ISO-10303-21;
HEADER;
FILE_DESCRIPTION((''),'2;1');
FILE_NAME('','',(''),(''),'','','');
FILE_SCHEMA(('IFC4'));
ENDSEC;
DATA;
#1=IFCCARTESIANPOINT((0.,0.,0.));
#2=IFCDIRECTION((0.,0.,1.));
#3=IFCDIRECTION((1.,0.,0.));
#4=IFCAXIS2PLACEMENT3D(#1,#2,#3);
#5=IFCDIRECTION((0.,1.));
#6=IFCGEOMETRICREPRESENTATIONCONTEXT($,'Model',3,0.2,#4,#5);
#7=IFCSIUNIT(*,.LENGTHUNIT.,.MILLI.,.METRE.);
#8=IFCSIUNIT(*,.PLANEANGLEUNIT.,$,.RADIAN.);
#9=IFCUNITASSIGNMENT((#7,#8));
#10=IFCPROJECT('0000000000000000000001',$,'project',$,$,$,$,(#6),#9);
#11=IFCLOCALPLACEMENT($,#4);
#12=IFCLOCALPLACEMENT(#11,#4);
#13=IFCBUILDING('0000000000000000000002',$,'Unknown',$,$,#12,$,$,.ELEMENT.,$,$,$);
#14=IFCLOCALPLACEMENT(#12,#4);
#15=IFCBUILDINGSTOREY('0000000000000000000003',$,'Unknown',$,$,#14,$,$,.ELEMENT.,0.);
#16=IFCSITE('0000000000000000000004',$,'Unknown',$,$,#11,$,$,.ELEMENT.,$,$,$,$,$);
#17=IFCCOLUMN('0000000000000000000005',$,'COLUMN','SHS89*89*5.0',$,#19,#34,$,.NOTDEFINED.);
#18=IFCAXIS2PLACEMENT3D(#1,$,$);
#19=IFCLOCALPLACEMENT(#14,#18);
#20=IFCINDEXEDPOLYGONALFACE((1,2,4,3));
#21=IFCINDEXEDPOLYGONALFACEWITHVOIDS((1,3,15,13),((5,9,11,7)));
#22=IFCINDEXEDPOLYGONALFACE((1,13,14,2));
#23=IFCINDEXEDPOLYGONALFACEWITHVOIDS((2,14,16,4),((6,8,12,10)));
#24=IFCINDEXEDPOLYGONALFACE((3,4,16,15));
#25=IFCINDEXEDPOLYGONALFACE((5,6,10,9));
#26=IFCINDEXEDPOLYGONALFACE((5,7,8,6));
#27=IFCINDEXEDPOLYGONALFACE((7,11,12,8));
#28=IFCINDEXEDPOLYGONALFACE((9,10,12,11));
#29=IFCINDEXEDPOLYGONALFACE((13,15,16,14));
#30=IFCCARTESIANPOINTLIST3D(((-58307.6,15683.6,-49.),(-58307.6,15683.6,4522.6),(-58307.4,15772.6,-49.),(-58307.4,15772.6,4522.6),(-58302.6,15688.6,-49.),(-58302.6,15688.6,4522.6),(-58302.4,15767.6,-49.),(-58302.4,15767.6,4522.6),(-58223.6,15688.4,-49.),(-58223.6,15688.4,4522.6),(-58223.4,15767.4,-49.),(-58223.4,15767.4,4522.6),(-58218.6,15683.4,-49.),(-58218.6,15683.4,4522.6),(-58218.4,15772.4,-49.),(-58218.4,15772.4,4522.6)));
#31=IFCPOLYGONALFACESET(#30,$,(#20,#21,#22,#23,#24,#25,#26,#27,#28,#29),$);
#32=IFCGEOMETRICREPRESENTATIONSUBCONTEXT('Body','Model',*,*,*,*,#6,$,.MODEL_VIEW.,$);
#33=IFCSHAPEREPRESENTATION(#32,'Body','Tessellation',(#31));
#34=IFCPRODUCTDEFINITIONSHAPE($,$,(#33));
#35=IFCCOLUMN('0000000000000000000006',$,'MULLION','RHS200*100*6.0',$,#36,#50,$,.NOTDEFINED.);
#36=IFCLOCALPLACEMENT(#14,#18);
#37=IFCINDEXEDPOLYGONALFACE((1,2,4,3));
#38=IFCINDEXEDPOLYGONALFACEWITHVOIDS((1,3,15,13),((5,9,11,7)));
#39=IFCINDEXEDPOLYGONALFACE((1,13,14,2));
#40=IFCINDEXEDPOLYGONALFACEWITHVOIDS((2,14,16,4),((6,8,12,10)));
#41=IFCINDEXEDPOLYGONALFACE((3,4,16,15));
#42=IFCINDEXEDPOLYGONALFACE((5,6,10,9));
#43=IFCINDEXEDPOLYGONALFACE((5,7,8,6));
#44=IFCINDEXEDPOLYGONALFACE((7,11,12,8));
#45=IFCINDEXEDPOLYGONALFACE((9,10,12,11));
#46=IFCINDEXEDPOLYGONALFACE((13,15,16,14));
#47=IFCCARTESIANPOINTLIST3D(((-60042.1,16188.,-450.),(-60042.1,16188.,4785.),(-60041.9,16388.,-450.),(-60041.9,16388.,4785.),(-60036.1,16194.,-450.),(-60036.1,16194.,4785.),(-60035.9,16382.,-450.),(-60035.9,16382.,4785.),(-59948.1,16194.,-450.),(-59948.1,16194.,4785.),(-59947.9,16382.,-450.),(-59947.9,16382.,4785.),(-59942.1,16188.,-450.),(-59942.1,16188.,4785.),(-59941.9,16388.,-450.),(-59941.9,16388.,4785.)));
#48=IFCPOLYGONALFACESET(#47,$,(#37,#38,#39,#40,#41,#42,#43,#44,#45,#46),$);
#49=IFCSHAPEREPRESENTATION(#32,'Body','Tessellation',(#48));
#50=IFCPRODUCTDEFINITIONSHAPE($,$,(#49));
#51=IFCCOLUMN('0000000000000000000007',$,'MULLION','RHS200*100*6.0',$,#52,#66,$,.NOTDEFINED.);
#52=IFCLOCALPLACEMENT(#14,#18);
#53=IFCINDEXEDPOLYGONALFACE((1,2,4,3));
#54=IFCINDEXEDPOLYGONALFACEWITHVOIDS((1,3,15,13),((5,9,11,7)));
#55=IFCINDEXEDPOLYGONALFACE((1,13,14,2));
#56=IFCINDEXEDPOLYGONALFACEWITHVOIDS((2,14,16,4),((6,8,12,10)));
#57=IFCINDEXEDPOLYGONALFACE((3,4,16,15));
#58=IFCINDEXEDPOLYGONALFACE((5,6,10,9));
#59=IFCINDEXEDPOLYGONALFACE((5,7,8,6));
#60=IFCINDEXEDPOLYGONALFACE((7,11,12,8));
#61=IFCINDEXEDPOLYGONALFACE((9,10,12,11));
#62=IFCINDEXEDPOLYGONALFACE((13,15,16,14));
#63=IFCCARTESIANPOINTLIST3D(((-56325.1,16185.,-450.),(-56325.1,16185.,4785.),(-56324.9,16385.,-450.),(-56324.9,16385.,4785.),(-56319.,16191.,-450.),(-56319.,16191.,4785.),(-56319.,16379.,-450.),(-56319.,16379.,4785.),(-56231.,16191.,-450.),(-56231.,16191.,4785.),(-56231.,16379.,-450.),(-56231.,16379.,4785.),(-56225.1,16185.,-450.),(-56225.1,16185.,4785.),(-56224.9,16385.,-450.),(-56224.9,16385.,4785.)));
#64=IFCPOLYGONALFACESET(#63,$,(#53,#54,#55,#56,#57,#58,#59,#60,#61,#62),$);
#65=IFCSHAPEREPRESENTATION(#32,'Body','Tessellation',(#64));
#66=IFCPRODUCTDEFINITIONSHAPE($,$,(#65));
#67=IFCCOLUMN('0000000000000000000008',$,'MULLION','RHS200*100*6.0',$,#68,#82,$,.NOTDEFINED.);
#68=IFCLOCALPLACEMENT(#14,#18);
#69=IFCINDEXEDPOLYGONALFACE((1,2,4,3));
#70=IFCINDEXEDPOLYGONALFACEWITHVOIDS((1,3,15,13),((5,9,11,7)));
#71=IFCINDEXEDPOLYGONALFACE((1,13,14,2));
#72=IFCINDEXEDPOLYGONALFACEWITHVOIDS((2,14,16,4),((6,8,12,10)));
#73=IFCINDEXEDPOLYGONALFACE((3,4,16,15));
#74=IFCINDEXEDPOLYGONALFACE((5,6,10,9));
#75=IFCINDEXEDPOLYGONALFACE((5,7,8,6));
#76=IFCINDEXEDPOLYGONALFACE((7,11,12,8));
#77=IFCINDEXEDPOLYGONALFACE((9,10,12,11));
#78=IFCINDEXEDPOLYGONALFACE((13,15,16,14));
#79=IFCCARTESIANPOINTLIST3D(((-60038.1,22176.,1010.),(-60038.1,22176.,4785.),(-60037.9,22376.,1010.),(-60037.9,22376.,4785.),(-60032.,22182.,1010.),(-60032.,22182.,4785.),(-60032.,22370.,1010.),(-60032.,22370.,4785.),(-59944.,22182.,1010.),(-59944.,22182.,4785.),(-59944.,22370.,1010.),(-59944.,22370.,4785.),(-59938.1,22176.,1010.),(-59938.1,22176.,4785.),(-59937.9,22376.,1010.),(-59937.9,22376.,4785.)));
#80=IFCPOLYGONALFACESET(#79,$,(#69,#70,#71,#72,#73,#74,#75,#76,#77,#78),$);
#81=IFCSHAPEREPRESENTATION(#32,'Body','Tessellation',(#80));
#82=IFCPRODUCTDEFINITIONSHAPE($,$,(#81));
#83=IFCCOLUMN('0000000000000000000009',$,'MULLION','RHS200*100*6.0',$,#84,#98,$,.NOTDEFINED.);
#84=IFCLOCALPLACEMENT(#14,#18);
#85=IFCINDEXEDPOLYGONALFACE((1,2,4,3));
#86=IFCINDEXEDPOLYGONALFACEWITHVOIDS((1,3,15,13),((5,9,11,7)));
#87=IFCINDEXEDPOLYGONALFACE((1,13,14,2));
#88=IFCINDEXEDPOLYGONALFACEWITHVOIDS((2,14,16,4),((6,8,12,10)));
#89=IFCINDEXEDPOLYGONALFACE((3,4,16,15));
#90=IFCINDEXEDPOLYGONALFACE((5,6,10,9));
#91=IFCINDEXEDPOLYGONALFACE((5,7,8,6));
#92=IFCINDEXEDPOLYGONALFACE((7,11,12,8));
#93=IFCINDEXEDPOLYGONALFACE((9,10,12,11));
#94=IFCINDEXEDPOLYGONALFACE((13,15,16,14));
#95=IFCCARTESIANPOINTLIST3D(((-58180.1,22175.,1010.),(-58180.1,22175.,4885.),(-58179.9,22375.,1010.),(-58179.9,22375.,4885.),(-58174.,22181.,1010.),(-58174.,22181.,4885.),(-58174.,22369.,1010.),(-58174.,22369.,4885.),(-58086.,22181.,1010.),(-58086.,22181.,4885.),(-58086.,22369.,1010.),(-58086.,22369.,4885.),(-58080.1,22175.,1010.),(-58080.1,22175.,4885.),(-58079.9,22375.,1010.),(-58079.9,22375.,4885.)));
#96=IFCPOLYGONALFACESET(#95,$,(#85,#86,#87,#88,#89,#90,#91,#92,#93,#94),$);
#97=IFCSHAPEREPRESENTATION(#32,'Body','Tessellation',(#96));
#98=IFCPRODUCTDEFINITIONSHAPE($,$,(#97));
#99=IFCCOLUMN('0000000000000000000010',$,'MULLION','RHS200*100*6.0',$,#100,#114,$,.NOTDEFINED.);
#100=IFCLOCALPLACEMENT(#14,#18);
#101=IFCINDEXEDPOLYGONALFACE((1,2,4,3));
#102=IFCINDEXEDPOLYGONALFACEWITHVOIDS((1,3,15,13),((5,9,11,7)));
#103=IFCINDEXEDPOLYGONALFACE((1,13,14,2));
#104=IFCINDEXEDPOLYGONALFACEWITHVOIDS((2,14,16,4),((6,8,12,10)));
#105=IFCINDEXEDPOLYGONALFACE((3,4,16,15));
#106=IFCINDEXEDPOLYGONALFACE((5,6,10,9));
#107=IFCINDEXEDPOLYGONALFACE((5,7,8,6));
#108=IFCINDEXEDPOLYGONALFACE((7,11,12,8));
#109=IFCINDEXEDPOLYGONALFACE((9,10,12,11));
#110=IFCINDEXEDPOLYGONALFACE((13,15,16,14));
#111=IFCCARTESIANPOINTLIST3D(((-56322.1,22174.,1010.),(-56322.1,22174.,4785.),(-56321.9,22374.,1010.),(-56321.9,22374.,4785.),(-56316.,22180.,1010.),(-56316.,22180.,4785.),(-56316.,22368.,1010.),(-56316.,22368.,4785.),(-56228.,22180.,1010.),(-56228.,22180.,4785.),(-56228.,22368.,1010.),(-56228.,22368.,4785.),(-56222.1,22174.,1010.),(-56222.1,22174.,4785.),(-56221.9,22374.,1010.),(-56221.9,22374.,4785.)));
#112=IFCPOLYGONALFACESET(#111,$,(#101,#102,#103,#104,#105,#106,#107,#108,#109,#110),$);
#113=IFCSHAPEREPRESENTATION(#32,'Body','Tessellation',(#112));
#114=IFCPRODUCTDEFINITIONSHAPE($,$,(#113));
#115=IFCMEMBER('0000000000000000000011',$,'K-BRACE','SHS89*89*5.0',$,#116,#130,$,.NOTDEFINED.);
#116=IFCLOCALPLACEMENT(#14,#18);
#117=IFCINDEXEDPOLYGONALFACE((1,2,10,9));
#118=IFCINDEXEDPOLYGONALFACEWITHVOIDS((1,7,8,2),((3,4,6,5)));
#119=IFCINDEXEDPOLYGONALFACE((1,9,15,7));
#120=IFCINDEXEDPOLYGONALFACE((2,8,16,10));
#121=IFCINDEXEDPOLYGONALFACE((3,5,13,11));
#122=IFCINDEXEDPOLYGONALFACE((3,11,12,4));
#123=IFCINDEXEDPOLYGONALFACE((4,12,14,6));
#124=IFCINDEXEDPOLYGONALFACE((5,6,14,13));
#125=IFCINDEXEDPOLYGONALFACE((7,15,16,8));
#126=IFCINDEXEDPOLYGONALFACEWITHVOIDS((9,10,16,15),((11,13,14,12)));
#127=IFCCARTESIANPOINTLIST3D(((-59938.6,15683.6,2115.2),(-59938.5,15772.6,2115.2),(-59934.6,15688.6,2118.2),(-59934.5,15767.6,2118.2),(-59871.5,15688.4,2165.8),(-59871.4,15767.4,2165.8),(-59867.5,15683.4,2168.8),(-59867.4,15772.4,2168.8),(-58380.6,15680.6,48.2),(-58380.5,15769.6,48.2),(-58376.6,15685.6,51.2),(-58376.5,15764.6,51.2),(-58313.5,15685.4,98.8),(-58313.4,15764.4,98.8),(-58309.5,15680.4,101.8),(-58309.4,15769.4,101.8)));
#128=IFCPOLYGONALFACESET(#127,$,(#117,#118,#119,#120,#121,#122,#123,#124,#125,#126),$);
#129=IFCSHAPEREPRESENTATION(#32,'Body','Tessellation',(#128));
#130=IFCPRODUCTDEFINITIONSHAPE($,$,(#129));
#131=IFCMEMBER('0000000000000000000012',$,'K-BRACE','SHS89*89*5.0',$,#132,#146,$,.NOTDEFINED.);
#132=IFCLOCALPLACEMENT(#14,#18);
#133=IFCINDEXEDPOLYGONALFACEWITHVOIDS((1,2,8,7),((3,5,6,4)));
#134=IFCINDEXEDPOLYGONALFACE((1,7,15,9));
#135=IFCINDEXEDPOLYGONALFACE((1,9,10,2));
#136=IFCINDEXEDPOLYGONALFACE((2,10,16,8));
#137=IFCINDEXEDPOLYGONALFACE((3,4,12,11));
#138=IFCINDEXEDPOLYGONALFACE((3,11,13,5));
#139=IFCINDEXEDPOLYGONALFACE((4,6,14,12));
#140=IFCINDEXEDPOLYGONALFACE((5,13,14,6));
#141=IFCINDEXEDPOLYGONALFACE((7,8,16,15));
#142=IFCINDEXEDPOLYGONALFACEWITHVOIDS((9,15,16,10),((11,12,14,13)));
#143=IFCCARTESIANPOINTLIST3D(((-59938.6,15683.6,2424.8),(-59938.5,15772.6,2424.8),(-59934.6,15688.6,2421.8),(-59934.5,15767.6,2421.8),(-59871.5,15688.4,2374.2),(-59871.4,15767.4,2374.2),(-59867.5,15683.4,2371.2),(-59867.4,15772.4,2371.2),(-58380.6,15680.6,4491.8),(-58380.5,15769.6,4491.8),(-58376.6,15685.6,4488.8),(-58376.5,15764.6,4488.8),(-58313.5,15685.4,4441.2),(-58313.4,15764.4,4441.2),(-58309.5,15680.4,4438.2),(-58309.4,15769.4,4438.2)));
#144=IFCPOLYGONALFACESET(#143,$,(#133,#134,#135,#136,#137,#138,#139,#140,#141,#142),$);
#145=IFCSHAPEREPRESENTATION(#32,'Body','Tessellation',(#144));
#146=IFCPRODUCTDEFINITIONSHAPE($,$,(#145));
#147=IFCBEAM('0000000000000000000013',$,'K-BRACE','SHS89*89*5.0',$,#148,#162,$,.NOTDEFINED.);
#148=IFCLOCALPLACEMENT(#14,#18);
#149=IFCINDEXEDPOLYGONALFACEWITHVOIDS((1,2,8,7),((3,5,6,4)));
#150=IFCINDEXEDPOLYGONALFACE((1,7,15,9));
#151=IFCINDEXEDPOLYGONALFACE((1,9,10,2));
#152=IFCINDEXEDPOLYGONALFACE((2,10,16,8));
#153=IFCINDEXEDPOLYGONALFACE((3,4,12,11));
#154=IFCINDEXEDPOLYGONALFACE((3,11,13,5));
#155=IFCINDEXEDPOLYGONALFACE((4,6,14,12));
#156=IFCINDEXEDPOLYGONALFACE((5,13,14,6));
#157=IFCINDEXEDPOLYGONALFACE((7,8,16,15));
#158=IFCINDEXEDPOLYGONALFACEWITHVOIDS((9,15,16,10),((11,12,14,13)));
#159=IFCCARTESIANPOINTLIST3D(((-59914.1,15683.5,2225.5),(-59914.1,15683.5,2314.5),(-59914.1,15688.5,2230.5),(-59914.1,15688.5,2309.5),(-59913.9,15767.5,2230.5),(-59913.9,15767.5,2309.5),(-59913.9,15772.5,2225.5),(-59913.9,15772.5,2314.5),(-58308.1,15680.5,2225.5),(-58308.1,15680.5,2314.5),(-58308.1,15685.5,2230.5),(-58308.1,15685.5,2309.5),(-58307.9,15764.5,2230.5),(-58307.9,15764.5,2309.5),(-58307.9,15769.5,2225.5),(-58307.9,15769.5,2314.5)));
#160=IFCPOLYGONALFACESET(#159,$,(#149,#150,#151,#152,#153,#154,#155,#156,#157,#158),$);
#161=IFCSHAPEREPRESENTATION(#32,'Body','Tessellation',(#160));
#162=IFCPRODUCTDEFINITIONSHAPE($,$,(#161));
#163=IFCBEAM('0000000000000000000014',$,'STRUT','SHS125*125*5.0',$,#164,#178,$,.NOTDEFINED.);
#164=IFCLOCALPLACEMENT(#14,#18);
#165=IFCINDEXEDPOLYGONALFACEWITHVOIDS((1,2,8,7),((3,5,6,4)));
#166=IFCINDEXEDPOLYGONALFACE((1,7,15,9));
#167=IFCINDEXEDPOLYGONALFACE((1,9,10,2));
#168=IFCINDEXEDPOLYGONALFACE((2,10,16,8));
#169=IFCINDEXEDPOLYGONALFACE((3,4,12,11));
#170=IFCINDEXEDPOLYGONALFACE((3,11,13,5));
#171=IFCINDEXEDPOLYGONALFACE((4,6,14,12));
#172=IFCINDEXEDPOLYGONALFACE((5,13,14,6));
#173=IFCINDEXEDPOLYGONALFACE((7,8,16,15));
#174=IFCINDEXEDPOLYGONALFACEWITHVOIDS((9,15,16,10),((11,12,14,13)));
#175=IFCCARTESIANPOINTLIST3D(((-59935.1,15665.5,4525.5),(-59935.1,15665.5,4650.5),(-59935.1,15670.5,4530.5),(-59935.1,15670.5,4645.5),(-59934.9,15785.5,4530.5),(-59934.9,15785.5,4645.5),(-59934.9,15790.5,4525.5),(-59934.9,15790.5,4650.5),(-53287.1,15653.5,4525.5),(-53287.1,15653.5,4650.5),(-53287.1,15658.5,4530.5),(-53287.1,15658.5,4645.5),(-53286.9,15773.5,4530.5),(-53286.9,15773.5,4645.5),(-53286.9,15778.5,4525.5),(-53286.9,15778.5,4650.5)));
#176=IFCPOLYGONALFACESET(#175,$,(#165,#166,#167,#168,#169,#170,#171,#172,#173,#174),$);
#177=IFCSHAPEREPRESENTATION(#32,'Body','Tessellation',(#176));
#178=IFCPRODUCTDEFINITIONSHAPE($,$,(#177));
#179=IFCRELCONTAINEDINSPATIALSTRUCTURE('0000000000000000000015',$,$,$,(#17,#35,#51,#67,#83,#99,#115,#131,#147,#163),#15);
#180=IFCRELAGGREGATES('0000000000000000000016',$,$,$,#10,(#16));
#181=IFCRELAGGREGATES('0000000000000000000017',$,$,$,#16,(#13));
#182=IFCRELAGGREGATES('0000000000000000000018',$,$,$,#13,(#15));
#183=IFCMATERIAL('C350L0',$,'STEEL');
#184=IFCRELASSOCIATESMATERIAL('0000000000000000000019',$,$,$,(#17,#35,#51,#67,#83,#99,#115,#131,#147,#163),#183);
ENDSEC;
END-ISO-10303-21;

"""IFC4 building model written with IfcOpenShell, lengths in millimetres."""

from ifc_helpers import new_model, si_unit, direction, frame, origin_with_axes, place, context, subcontext, project, spatial, line, indexed_curve, outline, extrude, material, element, save


model = new_model("IFC4")

# Units and contexts
model_context = context("Model", 3, precision=0.2, world=origin_with_axes(), true_north=direction((0.0, 1.0)))
body_context = subcontext(model_context, "Body", "Model", "MODEL_VIEW")
ifc_project = project(units=[si_unit("LENGTHUNIT", "METRE", prefix="MILLI"), si_unit("PLANEANGLEUNIT", "RADIAN")], contexts=[model_context])

# Site, building, storey
site_placement = place(None, origin_with_axes())
site = spatial("IfcSite", under=ifc_project, at=site_placement, Name="Unknown", CompositionType="ELEMENT")
building_placement = place(site_placement, origin_with_axes())
building = spatial("IfcBuilding", under=site, at=building_placement, Name="Unknown", CompositionType="ELEMENT")
storey_placement = place(building_placement, origin_with_axes())
storey = spatial("IfcBuildingStorey", under=building, at=storey_placement, Name="Unknown", CompositionType="ELEMENT", Elevation=0.0)

# Columns
ifc_material_1 = material(Name="C350L0", Category="STEEL")
column_1_placement = place(storey_placement, frame((-58263.0, 15728.0, -49.0), z_axis=(0.001745, 0.999998, 0.0), x_axis=(0.0, 0.0, 1.0)))
element("IfcColumn", 1, at=column_1_placement, inside=storey, material=ifc_material_1, Name="COLUMN", Description="SHS89*89*5.0", PredefinedType="NOTDEFINED", context=body_context, shape_type="SolidModel", body=[
    extrude(outline(indexed_curve([(-44.5, -44.5), (44.5, -44.5), (44.5, 44.5), (-44.5, 44.5)], segments=[line(1, 2, 3, 4, 1)]), holes=[indexed_curve([(-39.5, -39.5), (-39.5, 39.5), (39.5, 39.5), (39.5, -39.5)], segments=[line(1, 2, 3, 4, 1)])]), frame((0.0, 0.0, 0.0), z_axis=(-1.0, 0.0, 0.0), x_axis=(0.0, 0.0, 1.0)), (0.0, 0.0, -1.0), 4571.6),
])
for number, where, z_axis, x_axis, name in (
    (2, (-59992.0, 16288.0, -450.0), (1.0, -0.000873, 0.0), (0.0, 0.0, 1.0), "MULLION"),
    (3, (-56275.0, 16285.0, -450.0), (1.0, -0.000524, 0.0), (0.0, 0.0, 1.0), "MULLION"),
):
    element("IfcColumn", number, at=place(storey_placement, frame(where, z_axis=z_axis, x_axis=x_axis)), inside=storey, material=ifc_material_1, Name=name, Description="RHS200*100*6.0", PredefinedType="NOTDEFINED", context=body_context, shape_type="SolidModel", body=[
        extrude(outline(indexed_curve([(-50.0, -100.0), (50.0, -100.0), (50.0, 100.0), (-50.0, 100.0)], segments=[line(1, 2, 3, 4, 1)]), holes=[indexed_curve([(-44.0, -94.0), (-44.0, 94.0), (44.0, 94.0), (44.0, -94.0)], segments=[line(1, 2, 3, 4, 1)])]), frame((0.0, 0.0, 0.0), z_axis=(-1.0, 0.0, 0.0), x_axis=(0.0, 0.0, 1.0)), (0.0, 0.0, -1.0), 5235.0),
    ])
column_2_placement = place(storey_placement, frame((-59988.0, 22276.0, 1010.0), z_axis=(1.0, -0.000524, 0.0), x_axis=(0.0, 0.0, 1.0)))
element("IfcColumn", 4, at=column_2_placement, inside=storey, material=ifc_material_1, Name="MULLION", Description="RHS200*100*6.0", PredefinedType="NOTDEFINED", context=body_context, shape_type="SolidModel", body=[
    extrude(outline(indexed_curve([(-50.0, -100.0), (50.0, -100.0), (50.0, 100.0), (-50.0, 100.0)], segments=[line(1, 2, 3, 4, 1)]), holes=[indexed_curve([(-44.0, -94.0), (-44.0, 94.0), (44.0, 94.0), (44.0, -94.0)], segments=[line(1, 2, 3, 4, 1)])]), frame((0.0, 0.0, 0.0), z_axis=(-1.0, 0.0, 0.0), x_axis=(0.0, 0.0, 1.0)), (0.0, 0.0, -1.0), 3775.0),
])
column_3_placement = place(storey_placement, frame((-58130.0, 22275.0, 1010.0), z_axis=(1.0, -0.000524, 0.0), x_axis=(0.0, 0.0, 1.0)))
element("IfcColumn", 5, at=column_3_placement, inside=storey, material=ifc_material_1, Name="MULLION", Description="RHS200*100*6.0", PredefinedType="NOTDEFINED", context=body_context, shape_type="SolidModel", body=[
    extrude(outline(indexed_curve([(-50.0, -100.0), (50.0, -100.0), (50.0, 100.0), (-50.0, 100.0)], segments=[line(1, 2, 3, 4, 1)]), holes=[indexed_curve([(-44.0, -94.0), (-44.0, 94.0), (44.0, 94.0), (44.0, -94.0)], segments=[line(1, 2, 3, 4, 1)])]), frame((0.0, 0.0, 0.0), z_axis=(-1.0, 0.0, 0.0), x_axis=(0.0, 0.0, 1.0)), (0.0, 0.0, -1.0), 3875.0),
])
column_4_placement = place(storey_placement, frame((-56272.0, 22274.0, 1010.0), z_axis=(1.0, -0.000524, 0.0), x_axis=(0.0, 0.0, 1.0)))
element("IfcColumn", 6, at=column_4_placement, inside=storey, material=ifc_material_1, Name="MULLION", Description="RHS200*100*6.0", PredefinedType="NOTDEFINED", context=body_context, shape_type="SolidModel", body=[
    extrude(outline(indexed_curve([(-50.0, -100.0), (50.0, -100.0), (50.0, 100.0), (-50.0, 100.0)], segments=[line(1, 2, 3, 4, 1)]), holes=[indexed_curve([(-44.0, -94.0), (-44.0, 94.0), (44.0, 94.0), (44.0, -94.0)], segments=[line(1, 2, 3, 4, 1)])]), frame((0.0, 0.0, 0.0), z_axis=(-1.0, 0.0, 0.0), x_axis=(0.0, 0.0, 1.0)), (0.0, 0.0, -1.0), 3775.0),
])

# Members
for number, where, z_axis, x_axis, name in (
    (7, (-59903.0, 15728.0, 2142.0), (0.798559, -0.001538, 0.601915), (0.601914, -0.001159, -0.79856), "K-BRACE"),
    (8, (-59903.0, 15728.0, 2398.0), (-0.798559, 0.001538, 0.601915), (0.601914, -0.001159, 0.79856), "K-BRACE"),
):
    element("IfcMember", number, at=place(storey_placement, frame(where, z_axis=z_axis, x_axis=x_axis)), inside=storey, material=ifc_material_1, Name=name, Description="SHS89*89*5.0", PredefinedType="NOTDEFINED", context=body_context, shape_type="SolidModel", body=[
        extrude(outline(indexed_curve([(-44.5, -44.5), (44.5, -44.5), (44.5, 44.5), (-44.5, 44.5)], segments=[line(1, 2, 3, 4, 1)]), holes=[indexed_curve([(-39.5, -39.5), (-39.5, 39.5), (39.5, 39.5), (39.5, -39.5)], segments=[line(1, 2, 3, 4, 1)])]), frame((0.0, 0.0, 0.0), z_axis=(-1.0, 0.0, 0.0), x_axis=(0.0, 0.0, 1.0)), (0.0, 0.0, -1.0), 2588.4),
    ])

# Beams
beam_1_placement = place(storey_placement, frame((-59914.0, 15728.0, 2270.0), z_axis=(0.0, 0.0, 1.0), x_axis=(0.999998, -0.001868, 0.0)))
element("IfcBeam", 9, at=beam_1_placement, inside=storey, material=ifc_material_1, Name="K-BRACE", Description="SHS89*89*5.0", PredefinedType="NOTDEFINED", context=body_context, shape_type="SolidModel", body=[
    extrude(outline(indexed_curve([(-44.5, -44.5), (44.5, -44.5), (44.5, 44.5), (-44.5, 44.5)], segments=[line(1, 2, 3, 4, 1)]), holes=[indexed_curve([(-39.5, -39.5), (-39.5, 39.5), (39.5, 39.5), (39.5, -39.5)], segments=[line(1, 2, 3, 4, 1)])]), frame((0.0, 0.0, 0.0), z_axis=(-1.0, 0.0, 0.0), x_axis=(0.0, 0.0, 1.0)), (0.0, 0.0, -1.0), 1606.0),
])
beam_2_placement = place(storey_placement, frame((-59935.0, 15728.0, 4588.0), z_axis=(0.0, 0.0, 1.0), x_axis=(0.999998, -0.001805, 0.0)))
element("IfcBeam", 10, at=beam_2_placement, inside=storey, material=ifc_material_1, Name="STRUT", Description="SHS125*125*5.0", PredefinedType="NOTDEFINED", context=body_context, shape_type="SolidModel", body=[
    extrude(outline(indexed_curve([(-62.5, -62.5), (62.5, -62.5), (62.5, 62.5), (-62.5, 62.5)], segments=[line(1, 2, 3, 4, 1)]), holes=[indexed_curve([(-57.5, -57.5), (-57.5, 57.5), (57.5, 57.5), (57.5, -57.5)], segments=[line(1, 2, 3, 4, 1)])]), frame((0.0, 0.0, 0.0), z_axis=(-1.0, 0.0, 0.0), x_axis=(0.0, 0.0, 1.0)), (0.0, 0.0, -1.0), 6648.0),
])

save(model, "model.ifc")
